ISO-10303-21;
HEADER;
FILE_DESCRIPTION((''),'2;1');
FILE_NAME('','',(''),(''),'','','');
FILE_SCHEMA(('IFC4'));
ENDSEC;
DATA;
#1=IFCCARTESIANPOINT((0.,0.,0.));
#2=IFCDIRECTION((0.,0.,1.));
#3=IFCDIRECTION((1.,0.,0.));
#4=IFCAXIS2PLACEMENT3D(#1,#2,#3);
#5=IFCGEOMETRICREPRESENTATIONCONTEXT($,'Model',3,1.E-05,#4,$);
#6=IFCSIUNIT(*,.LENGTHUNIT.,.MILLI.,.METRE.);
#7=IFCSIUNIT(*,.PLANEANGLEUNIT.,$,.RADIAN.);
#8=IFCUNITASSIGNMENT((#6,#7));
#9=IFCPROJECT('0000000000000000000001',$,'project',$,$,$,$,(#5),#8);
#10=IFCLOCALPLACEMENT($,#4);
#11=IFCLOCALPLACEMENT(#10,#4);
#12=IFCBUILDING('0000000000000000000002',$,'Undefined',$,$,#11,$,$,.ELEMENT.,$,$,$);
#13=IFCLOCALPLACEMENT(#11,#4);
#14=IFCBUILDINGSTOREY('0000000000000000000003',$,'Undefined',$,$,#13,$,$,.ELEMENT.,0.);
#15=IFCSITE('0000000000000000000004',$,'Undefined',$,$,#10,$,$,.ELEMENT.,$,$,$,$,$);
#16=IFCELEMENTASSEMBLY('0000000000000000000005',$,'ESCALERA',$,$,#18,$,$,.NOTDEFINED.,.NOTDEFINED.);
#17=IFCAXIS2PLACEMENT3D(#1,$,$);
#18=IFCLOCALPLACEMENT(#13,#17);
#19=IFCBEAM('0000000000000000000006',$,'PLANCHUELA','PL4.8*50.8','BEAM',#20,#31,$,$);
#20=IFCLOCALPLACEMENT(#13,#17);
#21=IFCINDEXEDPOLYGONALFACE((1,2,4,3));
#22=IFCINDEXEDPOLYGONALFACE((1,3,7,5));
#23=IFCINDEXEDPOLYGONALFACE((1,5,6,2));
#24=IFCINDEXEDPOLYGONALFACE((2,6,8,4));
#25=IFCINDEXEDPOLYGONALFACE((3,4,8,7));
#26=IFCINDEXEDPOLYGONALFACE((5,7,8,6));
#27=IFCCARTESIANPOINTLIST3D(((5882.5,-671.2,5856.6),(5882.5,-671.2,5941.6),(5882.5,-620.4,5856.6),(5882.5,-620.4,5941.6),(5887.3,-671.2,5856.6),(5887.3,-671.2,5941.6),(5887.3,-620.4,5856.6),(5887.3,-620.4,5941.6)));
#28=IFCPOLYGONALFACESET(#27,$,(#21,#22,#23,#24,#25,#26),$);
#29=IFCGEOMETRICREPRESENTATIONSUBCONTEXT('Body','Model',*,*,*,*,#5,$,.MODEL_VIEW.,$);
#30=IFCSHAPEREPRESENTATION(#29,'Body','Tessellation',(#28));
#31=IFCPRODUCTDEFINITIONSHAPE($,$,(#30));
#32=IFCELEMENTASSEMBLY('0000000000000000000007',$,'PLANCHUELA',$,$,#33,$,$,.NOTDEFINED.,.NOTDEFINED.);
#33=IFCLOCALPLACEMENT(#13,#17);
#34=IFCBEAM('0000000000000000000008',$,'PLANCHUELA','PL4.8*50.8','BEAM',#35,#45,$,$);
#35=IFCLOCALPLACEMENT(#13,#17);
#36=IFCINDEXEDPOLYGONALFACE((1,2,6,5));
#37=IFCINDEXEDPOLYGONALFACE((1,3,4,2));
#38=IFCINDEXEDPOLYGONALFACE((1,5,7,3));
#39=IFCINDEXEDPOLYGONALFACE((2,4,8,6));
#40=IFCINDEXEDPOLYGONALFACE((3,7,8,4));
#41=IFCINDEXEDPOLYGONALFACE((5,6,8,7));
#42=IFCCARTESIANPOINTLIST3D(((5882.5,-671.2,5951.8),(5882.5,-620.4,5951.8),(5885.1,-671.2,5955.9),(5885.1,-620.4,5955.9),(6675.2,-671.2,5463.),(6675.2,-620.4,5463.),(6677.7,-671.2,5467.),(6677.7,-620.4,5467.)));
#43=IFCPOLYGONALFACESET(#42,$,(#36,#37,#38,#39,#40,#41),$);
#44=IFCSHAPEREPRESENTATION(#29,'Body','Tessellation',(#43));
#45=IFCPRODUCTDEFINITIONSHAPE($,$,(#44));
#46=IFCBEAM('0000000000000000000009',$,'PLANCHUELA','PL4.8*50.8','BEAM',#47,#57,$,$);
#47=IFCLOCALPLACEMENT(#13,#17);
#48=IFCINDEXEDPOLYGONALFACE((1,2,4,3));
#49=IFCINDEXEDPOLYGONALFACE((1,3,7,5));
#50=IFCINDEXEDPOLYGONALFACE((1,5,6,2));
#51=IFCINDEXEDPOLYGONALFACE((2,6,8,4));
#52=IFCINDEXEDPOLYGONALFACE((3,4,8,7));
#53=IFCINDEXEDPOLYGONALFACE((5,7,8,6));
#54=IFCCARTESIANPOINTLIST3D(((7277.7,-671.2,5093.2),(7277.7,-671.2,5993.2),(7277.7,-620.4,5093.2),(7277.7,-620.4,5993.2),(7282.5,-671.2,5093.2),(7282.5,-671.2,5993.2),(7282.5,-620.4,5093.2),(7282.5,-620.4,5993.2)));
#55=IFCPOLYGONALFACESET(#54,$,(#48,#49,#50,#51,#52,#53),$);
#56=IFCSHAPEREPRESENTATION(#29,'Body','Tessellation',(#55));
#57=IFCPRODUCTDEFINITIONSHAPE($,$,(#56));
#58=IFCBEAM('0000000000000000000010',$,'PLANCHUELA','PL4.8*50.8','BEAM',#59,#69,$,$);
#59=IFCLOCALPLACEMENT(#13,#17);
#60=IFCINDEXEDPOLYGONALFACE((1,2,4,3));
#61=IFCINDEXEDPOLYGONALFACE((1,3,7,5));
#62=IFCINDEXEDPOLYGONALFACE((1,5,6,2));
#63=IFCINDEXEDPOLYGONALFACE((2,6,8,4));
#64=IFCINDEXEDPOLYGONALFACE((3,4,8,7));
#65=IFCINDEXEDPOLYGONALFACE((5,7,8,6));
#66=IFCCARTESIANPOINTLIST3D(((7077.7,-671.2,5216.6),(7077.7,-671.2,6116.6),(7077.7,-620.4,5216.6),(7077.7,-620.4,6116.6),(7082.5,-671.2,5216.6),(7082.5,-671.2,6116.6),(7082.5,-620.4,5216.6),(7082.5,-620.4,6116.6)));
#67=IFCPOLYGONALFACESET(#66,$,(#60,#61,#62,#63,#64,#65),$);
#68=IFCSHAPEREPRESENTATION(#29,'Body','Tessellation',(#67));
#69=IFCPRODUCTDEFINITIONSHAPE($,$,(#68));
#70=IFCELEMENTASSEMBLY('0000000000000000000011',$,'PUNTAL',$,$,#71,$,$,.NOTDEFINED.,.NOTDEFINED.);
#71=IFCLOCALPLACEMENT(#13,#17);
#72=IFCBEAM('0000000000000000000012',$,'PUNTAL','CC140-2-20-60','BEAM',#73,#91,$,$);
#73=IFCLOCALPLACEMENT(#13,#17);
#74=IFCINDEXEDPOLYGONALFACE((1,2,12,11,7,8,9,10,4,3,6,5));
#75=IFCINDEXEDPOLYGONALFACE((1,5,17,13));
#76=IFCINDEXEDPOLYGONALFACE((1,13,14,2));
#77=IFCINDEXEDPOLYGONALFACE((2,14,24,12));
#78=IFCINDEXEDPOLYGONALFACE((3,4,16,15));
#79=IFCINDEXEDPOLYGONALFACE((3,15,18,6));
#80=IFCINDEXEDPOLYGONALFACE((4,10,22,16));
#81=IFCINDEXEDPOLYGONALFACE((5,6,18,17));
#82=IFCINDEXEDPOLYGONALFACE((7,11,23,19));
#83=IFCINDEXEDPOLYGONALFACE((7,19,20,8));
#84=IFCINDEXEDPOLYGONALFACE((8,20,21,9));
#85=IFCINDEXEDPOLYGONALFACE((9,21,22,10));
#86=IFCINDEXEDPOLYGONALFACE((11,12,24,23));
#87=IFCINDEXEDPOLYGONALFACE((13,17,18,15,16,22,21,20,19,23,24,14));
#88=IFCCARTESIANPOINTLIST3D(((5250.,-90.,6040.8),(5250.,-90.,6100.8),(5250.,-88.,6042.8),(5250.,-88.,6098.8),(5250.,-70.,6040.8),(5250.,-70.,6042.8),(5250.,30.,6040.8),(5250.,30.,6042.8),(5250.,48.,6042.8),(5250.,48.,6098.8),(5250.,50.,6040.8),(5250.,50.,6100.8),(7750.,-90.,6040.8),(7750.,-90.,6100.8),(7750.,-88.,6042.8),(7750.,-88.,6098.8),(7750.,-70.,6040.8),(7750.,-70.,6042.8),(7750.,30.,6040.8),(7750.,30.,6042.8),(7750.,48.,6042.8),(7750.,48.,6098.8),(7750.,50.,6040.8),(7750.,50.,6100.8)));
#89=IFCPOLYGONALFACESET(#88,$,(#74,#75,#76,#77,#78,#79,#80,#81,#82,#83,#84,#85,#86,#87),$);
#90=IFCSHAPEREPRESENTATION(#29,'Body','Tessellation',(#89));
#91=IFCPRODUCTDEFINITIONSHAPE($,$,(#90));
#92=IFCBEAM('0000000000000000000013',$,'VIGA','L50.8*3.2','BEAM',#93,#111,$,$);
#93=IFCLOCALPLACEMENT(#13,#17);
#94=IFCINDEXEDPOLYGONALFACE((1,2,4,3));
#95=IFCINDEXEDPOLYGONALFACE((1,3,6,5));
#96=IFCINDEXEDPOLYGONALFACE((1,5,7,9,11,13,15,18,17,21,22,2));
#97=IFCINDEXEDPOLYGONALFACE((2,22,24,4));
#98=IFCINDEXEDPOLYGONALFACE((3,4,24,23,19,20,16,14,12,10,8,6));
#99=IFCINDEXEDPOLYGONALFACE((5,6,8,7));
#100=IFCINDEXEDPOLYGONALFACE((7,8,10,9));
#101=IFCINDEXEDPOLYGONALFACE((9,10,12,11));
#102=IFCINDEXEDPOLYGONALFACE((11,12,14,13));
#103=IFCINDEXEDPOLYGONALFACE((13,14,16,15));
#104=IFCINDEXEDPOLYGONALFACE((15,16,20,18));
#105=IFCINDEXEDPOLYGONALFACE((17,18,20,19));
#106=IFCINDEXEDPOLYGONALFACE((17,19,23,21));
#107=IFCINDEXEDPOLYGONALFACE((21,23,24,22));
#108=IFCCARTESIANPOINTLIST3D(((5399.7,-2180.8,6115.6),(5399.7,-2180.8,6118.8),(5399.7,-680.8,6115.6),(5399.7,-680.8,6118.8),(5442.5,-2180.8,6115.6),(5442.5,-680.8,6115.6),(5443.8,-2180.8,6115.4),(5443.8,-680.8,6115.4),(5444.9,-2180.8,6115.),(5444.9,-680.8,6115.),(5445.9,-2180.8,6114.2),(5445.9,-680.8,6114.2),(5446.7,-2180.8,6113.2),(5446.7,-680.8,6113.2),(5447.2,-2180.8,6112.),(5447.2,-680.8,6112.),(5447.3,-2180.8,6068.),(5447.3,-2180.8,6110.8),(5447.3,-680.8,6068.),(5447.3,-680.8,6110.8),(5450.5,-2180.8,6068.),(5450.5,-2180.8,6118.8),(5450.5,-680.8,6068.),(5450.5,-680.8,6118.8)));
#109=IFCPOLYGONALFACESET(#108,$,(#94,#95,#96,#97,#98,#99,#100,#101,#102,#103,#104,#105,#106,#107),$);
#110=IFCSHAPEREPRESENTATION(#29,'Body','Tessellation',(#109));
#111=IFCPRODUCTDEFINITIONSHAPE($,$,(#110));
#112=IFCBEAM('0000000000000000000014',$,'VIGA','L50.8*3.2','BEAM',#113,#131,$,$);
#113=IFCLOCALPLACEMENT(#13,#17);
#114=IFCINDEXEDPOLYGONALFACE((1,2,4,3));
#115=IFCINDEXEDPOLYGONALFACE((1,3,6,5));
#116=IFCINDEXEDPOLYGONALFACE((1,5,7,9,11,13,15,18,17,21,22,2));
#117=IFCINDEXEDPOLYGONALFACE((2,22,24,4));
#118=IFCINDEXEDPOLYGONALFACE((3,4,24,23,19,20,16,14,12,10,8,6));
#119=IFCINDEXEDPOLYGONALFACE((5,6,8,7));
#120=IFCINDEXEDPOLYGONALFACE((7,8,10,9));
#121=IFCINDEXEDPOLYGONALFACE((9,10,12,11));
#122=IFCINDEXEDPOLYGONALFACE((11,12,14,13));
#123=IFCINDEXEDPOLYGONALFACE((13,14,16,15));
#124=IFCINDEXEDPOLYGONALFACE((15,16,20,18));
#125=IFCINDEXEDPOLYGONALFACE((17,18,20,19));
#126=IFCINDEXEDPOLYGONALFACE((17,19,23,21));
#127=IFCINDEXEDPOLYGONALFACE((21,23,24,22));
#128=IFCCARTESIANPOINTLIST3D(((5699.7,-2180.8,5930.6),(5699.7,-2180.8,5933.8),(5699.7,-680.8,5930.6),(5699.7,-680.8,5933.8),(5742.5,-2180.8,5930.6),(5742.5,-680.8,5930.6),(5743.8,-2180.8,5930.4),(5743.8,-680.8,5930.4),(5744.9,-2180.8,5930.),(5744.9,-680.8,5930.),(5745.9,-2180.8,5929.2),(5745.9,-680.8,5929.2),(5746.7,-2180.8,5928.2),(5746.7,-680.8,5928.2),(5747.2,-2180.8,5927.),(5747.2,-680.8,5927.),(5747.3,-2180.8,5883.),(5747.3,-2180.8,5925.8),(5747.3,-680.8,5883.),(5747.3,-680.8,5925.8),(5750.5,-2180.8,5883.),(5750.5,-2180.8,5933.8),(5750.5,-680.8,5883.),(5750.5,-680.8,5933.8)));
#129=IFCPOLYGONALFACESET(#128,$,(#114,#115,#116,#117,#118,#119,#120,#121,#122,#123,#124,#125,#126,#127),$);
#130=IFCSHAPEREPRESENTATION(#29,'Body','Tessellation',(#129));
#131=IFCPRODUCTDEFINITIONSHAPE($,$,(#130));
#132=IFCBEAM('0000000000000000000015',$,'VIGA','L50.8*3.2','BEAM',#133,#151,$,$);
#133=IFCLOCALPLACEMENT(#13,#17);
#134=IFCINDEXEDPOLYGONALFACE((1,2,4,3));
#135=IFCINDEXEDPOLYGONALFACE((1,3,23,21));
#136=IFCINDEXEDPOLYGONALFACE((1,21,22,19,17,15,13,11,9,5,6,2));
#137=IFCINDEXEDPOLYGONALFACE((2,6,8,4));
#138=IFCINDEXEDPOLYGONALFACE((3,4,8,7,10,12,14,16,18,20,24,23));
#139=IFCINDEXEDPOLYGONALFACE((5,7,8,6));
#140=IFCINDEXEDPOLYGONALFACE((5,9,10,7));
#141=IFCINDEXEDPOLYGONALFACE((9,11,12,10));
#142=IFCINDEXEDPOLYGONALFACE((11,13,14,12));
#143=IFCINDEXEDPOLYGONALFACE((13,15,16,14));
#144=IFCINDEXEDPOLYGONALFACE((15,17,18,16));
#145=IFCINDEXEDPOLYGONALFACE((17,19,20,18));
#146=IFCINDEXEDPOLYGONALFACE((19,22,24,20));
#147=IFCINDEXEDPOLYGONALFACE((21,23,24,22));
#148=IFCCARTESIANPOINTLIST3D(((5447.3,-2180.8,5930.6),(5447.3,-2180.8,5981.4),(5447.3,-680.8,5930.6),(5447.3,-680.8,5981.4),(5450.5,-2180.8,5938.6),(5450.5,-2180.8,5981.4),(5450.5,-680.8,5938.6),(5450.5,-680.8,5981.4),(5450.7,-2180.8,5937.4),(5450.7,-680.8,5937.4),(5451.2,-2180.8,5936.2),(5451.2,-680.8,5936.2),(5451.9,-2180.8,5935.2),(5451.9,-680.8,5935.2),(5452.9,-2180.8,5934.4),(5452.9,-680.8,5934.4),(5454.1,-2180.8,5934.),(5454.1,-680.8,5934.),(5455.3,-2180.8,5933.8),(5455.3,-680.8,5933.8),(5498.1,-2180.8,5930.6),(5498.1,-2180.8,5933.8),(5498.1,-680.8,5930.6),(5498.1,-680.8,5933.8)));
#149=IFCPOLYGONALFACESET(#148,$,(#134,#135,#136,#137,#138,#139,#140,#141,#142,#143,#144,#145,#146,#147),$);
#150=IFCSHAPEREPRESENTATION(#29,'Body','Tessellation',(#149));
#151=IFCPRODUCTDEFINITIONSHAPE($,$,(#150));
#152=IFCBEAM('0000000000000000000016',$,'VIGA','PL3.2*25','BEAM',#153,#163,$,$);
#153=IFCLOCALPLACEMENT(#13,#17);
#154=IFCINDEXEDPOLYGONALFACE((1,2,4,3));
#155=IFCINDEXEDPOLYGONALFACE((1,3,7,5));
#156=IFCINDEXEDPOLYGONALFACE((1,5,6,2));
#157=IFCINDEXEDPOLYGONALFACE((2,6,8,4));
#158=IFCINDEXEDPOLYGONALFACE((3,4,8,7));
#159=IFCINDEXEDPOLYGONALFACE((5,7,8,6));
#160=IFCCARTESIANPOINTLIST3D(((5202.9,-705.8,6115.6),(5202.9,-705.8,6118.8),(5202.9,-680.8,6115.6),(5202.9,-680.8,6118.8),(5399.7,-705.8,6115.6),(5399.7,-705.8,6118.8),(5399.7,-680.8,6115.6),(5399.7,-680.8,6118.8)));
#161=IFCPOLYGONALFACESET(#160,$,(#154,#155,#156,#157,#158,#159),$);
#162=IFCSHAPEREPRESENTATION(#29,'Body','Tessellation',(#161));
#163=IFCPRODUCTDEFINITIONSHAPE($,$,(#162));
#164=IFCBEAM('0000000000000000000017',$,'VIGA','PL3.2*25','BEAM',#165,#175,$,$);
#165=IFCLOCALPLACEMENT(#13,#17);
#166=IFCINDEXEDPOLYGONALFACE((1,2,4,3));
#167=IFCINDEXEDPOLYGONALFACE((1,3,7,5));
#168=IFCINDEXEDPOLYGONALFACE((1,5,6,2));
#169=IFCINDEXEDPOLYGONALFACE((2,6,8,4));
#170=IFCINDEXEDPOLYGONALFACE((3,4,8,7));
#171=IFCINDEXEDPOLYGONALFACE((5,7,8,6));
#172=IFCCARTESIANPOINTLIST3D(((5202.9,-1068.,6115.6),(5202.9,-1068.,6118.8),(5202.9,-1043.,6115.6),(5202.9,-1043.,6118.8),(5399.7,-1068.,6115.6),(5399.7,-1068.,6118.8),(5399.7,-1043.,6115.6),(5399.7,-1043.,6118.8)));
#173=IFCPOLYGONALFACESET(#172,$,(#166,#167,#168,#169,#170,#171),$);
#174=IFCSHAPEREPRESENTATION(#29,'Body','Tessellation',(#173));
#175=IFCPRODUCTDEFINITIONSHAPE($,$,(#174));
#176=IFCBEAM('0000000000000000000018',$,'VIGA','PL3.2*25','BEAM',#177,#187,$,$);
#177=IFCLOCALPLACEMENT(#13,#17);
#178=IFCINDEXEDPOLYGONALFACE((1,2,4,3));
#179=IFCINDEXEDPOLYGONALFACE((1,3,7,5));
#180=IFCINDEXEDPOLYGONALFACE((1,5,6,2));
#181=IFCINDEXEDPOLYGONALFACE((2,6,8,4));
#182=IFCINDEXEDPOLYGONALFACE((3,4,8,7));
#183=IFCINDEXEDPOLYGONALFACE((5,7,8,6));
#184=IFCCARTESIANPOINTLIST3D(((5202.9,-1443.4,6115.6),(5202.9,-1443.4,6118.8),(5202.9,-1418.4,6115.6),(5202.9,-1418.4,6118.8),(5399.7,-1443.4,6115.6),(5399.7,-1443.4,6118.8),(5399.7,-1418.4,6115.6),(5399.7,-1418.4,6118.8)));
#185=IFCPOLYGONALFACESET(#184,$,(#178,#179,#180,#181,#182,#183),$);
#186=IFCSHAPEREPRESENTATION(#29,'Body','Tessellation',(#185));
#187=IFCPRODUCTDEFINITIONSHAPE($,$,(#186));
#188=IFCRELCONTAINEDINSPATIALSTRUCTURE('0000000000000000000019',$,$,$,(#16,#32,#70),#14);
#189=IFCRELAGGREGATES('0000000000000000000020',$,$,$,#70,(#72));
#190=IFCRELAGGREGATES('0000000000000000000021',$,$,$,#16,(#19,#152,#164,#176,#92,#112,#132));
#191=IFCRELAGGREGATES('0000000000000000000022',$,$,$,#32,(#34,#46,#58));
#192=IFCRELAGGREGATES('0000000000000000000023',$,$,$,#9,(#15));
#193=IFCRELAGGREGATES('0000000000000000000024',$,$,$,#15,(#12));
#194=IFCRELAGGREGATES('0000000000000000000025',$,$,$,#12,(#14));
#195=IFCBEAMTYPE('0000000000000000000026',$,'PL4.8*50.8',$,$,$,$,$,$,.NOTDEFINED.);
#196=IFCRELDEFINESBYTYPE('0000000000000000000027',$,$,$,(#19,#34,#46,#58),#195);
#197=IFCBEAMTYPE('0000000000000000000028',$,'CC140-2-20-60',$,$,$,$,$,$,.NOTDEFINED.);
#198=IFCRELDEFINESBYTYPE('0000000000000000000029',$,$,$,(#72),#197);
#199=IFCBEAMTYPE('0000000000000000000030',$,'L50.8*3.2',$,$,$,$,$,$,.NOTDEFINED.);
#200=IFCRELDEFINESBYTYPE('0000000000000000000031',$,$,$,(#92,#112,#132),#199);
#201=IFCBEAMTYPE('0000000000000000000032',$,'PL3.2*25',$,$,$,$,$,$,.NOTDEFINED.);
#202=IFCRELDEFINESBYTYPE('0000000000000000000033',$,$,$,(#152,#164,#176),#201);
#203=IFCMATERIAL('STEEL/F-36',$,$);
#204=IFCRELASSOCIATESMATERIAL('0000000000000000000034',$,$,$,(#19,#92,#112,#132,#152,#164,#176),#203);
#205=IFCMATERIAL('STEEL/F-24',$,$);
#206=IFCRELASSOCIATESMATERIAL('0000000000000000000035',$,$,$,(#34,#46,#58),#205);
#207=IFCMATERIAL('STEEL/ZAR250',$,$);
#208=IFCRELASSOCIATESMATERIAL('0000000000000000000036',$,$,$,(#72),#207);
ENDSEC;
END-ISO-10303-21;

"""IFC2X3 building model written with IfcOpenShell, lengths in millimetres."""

from ifc_helpers import new_model, si_unit, frame, origin_with_axes, origin_2d_with_axis, place, context, subcontext, project, spatial, rectangle, l_section, c_section, extrude, material, type_object, element, aggregate, save


model = new_model("IFC2X3")

# Units and contexts
model_context = context("Model", 3, precision=1e-05, world=origin_with_axes())
body_context = subcontext(model_context, "Body", "Model", "MODEL_VIEW")
ifc_project = project(units=[si_unit("LENGTHUNIT", "METRE", prefix="MILLI"), si_unit("PLANEANGLEUNIT", "RADIAN")], contexts=[model_context])

# Site, building, storey
site_placement = place(None, origin_with_axes())
site = spatial("IfcSite", under=ifc_project, at=site_placement, Name="Undefined", CompositionType="ELEMENT")
building_placement = place(site_placement, origin_with_axes())
building = spatial("IfcBuilding", under=site, at=building_placement, Name="Undefined", CompositionType="ELEMENT")
storey_placement = place(building_placement, origin_with_axes())
storey = spatial("IfcBuildingStorey", under=building, at=storey_placement, Name="Undefined", CompositionType="ELEMENT", Elevation=0.0)

# Element assembly, beam
assembly_1_placement = place(storey_placement, origin_with_axes())
assembly_1 = element("IfcElementAssembly", 1, at=assembly_1_placement, inside=storey, Name="ESCALERA", AssemblyPlace="NOTDEFINED", PredefinedType="NOTDEFINED")
ifc_material_1 = material(Name="STEEL/F-36")
beam_type_1 = type_object("IfcBeamType", Name="PL4.8*50.8", PredefinedType="NOTDEFINED")
beam_1_placement = place(assembly_1_placement, frame((5884.9, -645.8, 5941.6), z_axis=(0.0, -1.0, 0.0), x_axis=(0.0, 0.0, -1.0)))
beam_1 = element("IfcBeam", 2, at=beam_1_placement, type_object=beam_type_1, material=ifc_material_1, Name="PLANCHUELA", Description="PL4.8*50.8", ObjectType="BEAM", context=body_context, shape_type="SweptSolid", body=[
    extrude(rectangle(XDim=4.8, YDim=50.8, at=origin_2d_with_axis()), frame((85.0, 0.0, 0.0), z_axis=(-1.0, 0.0, 0.0), x_axis=(0.0, -1.0, 0.0)), (0.0, 0.0, 1.0), 85.0),
])

# Element assembly, beams
assembly_2_placement = place(storey_placement, origin_with_axes())
assembly_2 = element("IfcElementAssembly", 3, at=assembly_2_placement, inside=storey, Name="PLANCHUELA", AssemblyPlace="NOTDEFINED", PredefinedType="NOTDEFINED")
ifc_material_2 = material(Name="STEEL/F-24")
beam_2_placement = place(assembly_2_placement, frame((5883.8, -645.8, 5953.8), z_axis=(0.0, -1.0, 0.0), x_axis=(0.851171, 0.0, -0.524889)))
beam_2 = element("IfcBeam", 4, at=beam_2_placement, type_object=beam_type_1, material=ifc_material_2, Name="PLANCHUELA", Description="PL4.8*50.8", ObjectType="BEAM", context=body_context, shape_type="SweptSolid", body=[
    extrude(rectangle(XDim=4.8, YDim=50.8, at=origin_2d_with_axis()), frame((931.3, 0.0, 0.0), z_axis=(-1.0, 0.0, 0.0), x_axis=(0.0, -1.0, 0.0)), (0.0, 0.0, 1.0), 931.3),
])
beam_3_placement = place(assembly_2_placement, frame((7280.1, -645.8, 5993.2), z_axis=(0.0, -1.0, 0.0), x_axis=(0.0, 0.0, -1.0)))
beam_3 = element("IfcBeam", 5, at=beam_3_placement, type_object=beam_type_1, material=ifc_material_2, Name="PLANCHUELA", Description="PL4.8*50.8", ObjectType="BEAM", context=body_context, shape_type="SweptSolid", body=[
    extrude(rectangle(XDim=4.8, YDim=50.8, at=origin_2d_with_axis()), frame((900.0, 0.0, 0.0), z_axis=(-1.0, 0.0, 0.0), x_axis=(0.0, -1.0, 0.0)), (0.0, 0.0, 1.0), 900.0),
])
beam_4_placement = place(assembly_2_placement, frame((7080.1, -645.8, 6116.6), z_axis=(0.0, -1.0, 0.0), x_axis=(0.0, 0.0, -1.0)))
beam_4 = element("IfcBeam", 6, at=beam_4_placement, type_object=beam_type_1, material=ifc_material_2, Name="PLANCHUELA", Description="PL4.8*50.8", ObjectType="BEAM", context=body_context, shape_type="SweptSolid", body=[
    extrude(rectangle(XDim=4.8, YDim=50.8, at=origin_2d_with_axis()), frame((900.0, 0.0, 0.0), z_axis=(-1.0, 0.0, 0.0), x_axis=(0.0, -1.0, 0.0)), (0.0, 0.0, 1.0), 900.0),
])

# Element assembly, beam
assembly_3_placement = place(storey_placement, origin_with_axes())
assembly_3 = element("IfcElementAssembly", 7, at=assembly_3_placement, inside=storey, Name="PUNTAL", AssemblyPlace="NOTDEFINED", PredefinedType="NOTDEFINED")
ifc_material_3 = material(Name="STEEL/ZAR250")
beam_type_2 = type_object("IfcBeamType", Name="CC140-2-20-60", PredefinedType="NOTDEFINED")
beam_5_placement = place(assembly_3_placement, frame((5250.0, -20.0, 6070.8), z_axis=(0.0, -1.0, 0.0), x_axis=(1.0, 0.0, 0.0)))
beam_5 = element("IfcBeam", 8, at=beam_5_placement, type_object=beam_type_2, material=ifc_material_3, Name="PUNTAL", Description="CC140-2-20-60", ObjectType="BEAM", context=body_context, shape_type="SweptSolid", body=[
    extrude(c_section(Depth=140.0, Width=60.0, WallThickness=2.0, Girth=20.0, at=origin_2d_with_axis()), frame((2500.0, 0.0, 0.0), z_axis=(-1.0, 0.0, 0.0), x_axis=(0.0, -1.0, 0.0)), (0.0, 0.0, 1.0), 2500.0),
])
aggregate(assembly_3, [beam_5])

# Beams
beam_type_3 = type_object("IfcBeamType", Name="L50.8*3.2", PredefinedType="NOTDEFINED")
beam_6_placement = place(assembly_1_placement, frame((5425.1, -680.8, 6093.4), z_axis=(-1.0, 0.0, -0.000045), x_axis=(0.0, -1.0, 0.0)))
beam_6 = element("IfcBeam", 9, at=beam_6_placement, type_object=beam_type_3, material=ifc_material_1, Name="VIGA", Description="L50.8*3.2", ObjectType="BEAM", context=body_context, shape_type="SweptSolid", body=[
    extrude(l_section(Depth=50.8, Width=50.8, Thickness=3.2, FilletRadius=4.8, at=origin_2d_with_axis()), frame((1500.0, 0.0, 0.0), z_axis=(-1.0, 0.0, 0.0), x_axis=(0.0, -1.0, 0.0)), (0.0, 0.0, 1.0), 1500.0),
])
beam_7_placement = place(assembly_1_placement, frame((5725.1, -680.8, 5908.4), z_axis=(-1.0, 0.0, -0.000045), x_axis=(0.0, -1.0, 0.0)))
beam_7 = element("IfcBeam", 10, at=beam_7_placement, type_object=beam_type_3, material=ifc_material_1, Name="VIGA", Description="L50.8*3.2", ObjectType="BEAM", context=body_context, shape_type="SweptSolid", body=[
    extrude(l_section(Depth=50.8, Width=50.8, Thickness=3.2, FilletRadius=4.8, at=origin_2d_with_axis()), frame((1500.0, 0.0, 0.0), z_axis=(-1.0, 0.0, 0.0), x_axis=(0.0, -1.0, 0.0)), (0.0, 0.0, 1.0), 1500.0),
])
beam_8_placement = place(assembly_1_placement, frame((5472.7, -680.8, 5956.0), z_axis=(1.0, 0.0, 0.000007), x_axis=(0.0, -1.0, 0.0)))
beam_8 = element("IfcBeam", 11, at=beam_8_placement, type_object=beam_type_3, material=ifc_material_1, Name="VIGA", Description="L50.8*3.2", ObjectType="BEAM", context=body_context, shape_type="SweptSolid", body=[
    extrude(l_section(Depth=50.8, Width=50.8, Thickness=3.2, FilletRadius=4.8, at=origin_2d_with_axis()), frame((1500.0, 0.0, 0.0), z_axis=(-1.0, 0.0, 0.0), x_axis=(0.0, -1.0, 0.0)), (0.0, 0.0, 1.0), 1500.0),
])
beam_type_4 = type_object("IfcBeamType", Name="PL3.2*25", PredefinedType="NOTDEFINED")
beam_9_placement = place(assembly_1_placement, frame((5399.7, -693.3, 6117.2), z_axis=(0.0, 1.0, 0.0), x_axis=(-1.0, 0.0, 0.000012)))
beam_9 = element("IfcBeam", 12, at=beam_9_placement, type_object=beam_type_4, material=ifc_material_1, Name="VIGA", Description="PL3.2*25", ObjectType="BEAM", context=body_context, shape_type="SweptSolid", body=[
    extrude(rectangle(XDim=3.2, YDim=25.0, at=origin_2d_with_axis()), frame((196.8, 0.0, 0.0), z_axis=(-1.0, 0.0, 0.0), x_axis=(0.0, -1.0, 0.0)), (0.0, 0.0, 1.0), 196.8),
])
beam_10_placement = place(assembly_1_placement, frame((5399.7, -1055.5, 6117.2), z_axis=(0.0, 1.0, 0.0), x_axis=(-1.0, 0.0, 0.000012)))
beam_10 = element("IfcBeam", 13, at=beam_10_placement, type_object=beam_type_4, material=ifc_material_1, Name="VIGA", Description="PL3.2*25", ObjectType="BEAM", context=body_context, shape_type="SweptSolid", body=[
    extrude(rectangle(XDim=3.2, YDim=25.0, at=origin_2d_with_axis()), frame((196.8, 0.0, 0.0), z_axis=(-1.0, 0.0, 0.0), x_axis=(0.0, -1.0, 0.0)), (0.0, 0.0, 1.0), 196.8),
])
beam_11_placement = place(assembly_1_placement, frame((5399.7, -1430.9, 6117.2), z_axis=(0.0, 1.0, 0.0), x_axis=(-1.0, 0.0, 0.000012)))
beam_11 = element("IfcBeam", 14, at=beam_11_placement, type_object=beam_type_4, material=ifc_material_1, Name="VIGA", Description="PL3.2*25", ObjectType="BEAM", context=body_context, shape_type="SweptSolid", body=[
    extrude(rectangle(XDim=3.2, YDim=25.0, at=origin_2d_with_axis()), frame((196.8, 0.0, 0.0), z_axis=(-1.0, 0.0, 0.0), x_axis=(0.0, -1.0, 0.0)), (0.0, 0.0, 1.0), 196.8),
])

aggregate(assembly_1, [beam_1, beam_9, beam_10, beam_11, beam_6, beam_7, beam_8])

aggregate(assembly_2, [beam_2, beam_3, beam_4])

save(model, "model.ifc")
